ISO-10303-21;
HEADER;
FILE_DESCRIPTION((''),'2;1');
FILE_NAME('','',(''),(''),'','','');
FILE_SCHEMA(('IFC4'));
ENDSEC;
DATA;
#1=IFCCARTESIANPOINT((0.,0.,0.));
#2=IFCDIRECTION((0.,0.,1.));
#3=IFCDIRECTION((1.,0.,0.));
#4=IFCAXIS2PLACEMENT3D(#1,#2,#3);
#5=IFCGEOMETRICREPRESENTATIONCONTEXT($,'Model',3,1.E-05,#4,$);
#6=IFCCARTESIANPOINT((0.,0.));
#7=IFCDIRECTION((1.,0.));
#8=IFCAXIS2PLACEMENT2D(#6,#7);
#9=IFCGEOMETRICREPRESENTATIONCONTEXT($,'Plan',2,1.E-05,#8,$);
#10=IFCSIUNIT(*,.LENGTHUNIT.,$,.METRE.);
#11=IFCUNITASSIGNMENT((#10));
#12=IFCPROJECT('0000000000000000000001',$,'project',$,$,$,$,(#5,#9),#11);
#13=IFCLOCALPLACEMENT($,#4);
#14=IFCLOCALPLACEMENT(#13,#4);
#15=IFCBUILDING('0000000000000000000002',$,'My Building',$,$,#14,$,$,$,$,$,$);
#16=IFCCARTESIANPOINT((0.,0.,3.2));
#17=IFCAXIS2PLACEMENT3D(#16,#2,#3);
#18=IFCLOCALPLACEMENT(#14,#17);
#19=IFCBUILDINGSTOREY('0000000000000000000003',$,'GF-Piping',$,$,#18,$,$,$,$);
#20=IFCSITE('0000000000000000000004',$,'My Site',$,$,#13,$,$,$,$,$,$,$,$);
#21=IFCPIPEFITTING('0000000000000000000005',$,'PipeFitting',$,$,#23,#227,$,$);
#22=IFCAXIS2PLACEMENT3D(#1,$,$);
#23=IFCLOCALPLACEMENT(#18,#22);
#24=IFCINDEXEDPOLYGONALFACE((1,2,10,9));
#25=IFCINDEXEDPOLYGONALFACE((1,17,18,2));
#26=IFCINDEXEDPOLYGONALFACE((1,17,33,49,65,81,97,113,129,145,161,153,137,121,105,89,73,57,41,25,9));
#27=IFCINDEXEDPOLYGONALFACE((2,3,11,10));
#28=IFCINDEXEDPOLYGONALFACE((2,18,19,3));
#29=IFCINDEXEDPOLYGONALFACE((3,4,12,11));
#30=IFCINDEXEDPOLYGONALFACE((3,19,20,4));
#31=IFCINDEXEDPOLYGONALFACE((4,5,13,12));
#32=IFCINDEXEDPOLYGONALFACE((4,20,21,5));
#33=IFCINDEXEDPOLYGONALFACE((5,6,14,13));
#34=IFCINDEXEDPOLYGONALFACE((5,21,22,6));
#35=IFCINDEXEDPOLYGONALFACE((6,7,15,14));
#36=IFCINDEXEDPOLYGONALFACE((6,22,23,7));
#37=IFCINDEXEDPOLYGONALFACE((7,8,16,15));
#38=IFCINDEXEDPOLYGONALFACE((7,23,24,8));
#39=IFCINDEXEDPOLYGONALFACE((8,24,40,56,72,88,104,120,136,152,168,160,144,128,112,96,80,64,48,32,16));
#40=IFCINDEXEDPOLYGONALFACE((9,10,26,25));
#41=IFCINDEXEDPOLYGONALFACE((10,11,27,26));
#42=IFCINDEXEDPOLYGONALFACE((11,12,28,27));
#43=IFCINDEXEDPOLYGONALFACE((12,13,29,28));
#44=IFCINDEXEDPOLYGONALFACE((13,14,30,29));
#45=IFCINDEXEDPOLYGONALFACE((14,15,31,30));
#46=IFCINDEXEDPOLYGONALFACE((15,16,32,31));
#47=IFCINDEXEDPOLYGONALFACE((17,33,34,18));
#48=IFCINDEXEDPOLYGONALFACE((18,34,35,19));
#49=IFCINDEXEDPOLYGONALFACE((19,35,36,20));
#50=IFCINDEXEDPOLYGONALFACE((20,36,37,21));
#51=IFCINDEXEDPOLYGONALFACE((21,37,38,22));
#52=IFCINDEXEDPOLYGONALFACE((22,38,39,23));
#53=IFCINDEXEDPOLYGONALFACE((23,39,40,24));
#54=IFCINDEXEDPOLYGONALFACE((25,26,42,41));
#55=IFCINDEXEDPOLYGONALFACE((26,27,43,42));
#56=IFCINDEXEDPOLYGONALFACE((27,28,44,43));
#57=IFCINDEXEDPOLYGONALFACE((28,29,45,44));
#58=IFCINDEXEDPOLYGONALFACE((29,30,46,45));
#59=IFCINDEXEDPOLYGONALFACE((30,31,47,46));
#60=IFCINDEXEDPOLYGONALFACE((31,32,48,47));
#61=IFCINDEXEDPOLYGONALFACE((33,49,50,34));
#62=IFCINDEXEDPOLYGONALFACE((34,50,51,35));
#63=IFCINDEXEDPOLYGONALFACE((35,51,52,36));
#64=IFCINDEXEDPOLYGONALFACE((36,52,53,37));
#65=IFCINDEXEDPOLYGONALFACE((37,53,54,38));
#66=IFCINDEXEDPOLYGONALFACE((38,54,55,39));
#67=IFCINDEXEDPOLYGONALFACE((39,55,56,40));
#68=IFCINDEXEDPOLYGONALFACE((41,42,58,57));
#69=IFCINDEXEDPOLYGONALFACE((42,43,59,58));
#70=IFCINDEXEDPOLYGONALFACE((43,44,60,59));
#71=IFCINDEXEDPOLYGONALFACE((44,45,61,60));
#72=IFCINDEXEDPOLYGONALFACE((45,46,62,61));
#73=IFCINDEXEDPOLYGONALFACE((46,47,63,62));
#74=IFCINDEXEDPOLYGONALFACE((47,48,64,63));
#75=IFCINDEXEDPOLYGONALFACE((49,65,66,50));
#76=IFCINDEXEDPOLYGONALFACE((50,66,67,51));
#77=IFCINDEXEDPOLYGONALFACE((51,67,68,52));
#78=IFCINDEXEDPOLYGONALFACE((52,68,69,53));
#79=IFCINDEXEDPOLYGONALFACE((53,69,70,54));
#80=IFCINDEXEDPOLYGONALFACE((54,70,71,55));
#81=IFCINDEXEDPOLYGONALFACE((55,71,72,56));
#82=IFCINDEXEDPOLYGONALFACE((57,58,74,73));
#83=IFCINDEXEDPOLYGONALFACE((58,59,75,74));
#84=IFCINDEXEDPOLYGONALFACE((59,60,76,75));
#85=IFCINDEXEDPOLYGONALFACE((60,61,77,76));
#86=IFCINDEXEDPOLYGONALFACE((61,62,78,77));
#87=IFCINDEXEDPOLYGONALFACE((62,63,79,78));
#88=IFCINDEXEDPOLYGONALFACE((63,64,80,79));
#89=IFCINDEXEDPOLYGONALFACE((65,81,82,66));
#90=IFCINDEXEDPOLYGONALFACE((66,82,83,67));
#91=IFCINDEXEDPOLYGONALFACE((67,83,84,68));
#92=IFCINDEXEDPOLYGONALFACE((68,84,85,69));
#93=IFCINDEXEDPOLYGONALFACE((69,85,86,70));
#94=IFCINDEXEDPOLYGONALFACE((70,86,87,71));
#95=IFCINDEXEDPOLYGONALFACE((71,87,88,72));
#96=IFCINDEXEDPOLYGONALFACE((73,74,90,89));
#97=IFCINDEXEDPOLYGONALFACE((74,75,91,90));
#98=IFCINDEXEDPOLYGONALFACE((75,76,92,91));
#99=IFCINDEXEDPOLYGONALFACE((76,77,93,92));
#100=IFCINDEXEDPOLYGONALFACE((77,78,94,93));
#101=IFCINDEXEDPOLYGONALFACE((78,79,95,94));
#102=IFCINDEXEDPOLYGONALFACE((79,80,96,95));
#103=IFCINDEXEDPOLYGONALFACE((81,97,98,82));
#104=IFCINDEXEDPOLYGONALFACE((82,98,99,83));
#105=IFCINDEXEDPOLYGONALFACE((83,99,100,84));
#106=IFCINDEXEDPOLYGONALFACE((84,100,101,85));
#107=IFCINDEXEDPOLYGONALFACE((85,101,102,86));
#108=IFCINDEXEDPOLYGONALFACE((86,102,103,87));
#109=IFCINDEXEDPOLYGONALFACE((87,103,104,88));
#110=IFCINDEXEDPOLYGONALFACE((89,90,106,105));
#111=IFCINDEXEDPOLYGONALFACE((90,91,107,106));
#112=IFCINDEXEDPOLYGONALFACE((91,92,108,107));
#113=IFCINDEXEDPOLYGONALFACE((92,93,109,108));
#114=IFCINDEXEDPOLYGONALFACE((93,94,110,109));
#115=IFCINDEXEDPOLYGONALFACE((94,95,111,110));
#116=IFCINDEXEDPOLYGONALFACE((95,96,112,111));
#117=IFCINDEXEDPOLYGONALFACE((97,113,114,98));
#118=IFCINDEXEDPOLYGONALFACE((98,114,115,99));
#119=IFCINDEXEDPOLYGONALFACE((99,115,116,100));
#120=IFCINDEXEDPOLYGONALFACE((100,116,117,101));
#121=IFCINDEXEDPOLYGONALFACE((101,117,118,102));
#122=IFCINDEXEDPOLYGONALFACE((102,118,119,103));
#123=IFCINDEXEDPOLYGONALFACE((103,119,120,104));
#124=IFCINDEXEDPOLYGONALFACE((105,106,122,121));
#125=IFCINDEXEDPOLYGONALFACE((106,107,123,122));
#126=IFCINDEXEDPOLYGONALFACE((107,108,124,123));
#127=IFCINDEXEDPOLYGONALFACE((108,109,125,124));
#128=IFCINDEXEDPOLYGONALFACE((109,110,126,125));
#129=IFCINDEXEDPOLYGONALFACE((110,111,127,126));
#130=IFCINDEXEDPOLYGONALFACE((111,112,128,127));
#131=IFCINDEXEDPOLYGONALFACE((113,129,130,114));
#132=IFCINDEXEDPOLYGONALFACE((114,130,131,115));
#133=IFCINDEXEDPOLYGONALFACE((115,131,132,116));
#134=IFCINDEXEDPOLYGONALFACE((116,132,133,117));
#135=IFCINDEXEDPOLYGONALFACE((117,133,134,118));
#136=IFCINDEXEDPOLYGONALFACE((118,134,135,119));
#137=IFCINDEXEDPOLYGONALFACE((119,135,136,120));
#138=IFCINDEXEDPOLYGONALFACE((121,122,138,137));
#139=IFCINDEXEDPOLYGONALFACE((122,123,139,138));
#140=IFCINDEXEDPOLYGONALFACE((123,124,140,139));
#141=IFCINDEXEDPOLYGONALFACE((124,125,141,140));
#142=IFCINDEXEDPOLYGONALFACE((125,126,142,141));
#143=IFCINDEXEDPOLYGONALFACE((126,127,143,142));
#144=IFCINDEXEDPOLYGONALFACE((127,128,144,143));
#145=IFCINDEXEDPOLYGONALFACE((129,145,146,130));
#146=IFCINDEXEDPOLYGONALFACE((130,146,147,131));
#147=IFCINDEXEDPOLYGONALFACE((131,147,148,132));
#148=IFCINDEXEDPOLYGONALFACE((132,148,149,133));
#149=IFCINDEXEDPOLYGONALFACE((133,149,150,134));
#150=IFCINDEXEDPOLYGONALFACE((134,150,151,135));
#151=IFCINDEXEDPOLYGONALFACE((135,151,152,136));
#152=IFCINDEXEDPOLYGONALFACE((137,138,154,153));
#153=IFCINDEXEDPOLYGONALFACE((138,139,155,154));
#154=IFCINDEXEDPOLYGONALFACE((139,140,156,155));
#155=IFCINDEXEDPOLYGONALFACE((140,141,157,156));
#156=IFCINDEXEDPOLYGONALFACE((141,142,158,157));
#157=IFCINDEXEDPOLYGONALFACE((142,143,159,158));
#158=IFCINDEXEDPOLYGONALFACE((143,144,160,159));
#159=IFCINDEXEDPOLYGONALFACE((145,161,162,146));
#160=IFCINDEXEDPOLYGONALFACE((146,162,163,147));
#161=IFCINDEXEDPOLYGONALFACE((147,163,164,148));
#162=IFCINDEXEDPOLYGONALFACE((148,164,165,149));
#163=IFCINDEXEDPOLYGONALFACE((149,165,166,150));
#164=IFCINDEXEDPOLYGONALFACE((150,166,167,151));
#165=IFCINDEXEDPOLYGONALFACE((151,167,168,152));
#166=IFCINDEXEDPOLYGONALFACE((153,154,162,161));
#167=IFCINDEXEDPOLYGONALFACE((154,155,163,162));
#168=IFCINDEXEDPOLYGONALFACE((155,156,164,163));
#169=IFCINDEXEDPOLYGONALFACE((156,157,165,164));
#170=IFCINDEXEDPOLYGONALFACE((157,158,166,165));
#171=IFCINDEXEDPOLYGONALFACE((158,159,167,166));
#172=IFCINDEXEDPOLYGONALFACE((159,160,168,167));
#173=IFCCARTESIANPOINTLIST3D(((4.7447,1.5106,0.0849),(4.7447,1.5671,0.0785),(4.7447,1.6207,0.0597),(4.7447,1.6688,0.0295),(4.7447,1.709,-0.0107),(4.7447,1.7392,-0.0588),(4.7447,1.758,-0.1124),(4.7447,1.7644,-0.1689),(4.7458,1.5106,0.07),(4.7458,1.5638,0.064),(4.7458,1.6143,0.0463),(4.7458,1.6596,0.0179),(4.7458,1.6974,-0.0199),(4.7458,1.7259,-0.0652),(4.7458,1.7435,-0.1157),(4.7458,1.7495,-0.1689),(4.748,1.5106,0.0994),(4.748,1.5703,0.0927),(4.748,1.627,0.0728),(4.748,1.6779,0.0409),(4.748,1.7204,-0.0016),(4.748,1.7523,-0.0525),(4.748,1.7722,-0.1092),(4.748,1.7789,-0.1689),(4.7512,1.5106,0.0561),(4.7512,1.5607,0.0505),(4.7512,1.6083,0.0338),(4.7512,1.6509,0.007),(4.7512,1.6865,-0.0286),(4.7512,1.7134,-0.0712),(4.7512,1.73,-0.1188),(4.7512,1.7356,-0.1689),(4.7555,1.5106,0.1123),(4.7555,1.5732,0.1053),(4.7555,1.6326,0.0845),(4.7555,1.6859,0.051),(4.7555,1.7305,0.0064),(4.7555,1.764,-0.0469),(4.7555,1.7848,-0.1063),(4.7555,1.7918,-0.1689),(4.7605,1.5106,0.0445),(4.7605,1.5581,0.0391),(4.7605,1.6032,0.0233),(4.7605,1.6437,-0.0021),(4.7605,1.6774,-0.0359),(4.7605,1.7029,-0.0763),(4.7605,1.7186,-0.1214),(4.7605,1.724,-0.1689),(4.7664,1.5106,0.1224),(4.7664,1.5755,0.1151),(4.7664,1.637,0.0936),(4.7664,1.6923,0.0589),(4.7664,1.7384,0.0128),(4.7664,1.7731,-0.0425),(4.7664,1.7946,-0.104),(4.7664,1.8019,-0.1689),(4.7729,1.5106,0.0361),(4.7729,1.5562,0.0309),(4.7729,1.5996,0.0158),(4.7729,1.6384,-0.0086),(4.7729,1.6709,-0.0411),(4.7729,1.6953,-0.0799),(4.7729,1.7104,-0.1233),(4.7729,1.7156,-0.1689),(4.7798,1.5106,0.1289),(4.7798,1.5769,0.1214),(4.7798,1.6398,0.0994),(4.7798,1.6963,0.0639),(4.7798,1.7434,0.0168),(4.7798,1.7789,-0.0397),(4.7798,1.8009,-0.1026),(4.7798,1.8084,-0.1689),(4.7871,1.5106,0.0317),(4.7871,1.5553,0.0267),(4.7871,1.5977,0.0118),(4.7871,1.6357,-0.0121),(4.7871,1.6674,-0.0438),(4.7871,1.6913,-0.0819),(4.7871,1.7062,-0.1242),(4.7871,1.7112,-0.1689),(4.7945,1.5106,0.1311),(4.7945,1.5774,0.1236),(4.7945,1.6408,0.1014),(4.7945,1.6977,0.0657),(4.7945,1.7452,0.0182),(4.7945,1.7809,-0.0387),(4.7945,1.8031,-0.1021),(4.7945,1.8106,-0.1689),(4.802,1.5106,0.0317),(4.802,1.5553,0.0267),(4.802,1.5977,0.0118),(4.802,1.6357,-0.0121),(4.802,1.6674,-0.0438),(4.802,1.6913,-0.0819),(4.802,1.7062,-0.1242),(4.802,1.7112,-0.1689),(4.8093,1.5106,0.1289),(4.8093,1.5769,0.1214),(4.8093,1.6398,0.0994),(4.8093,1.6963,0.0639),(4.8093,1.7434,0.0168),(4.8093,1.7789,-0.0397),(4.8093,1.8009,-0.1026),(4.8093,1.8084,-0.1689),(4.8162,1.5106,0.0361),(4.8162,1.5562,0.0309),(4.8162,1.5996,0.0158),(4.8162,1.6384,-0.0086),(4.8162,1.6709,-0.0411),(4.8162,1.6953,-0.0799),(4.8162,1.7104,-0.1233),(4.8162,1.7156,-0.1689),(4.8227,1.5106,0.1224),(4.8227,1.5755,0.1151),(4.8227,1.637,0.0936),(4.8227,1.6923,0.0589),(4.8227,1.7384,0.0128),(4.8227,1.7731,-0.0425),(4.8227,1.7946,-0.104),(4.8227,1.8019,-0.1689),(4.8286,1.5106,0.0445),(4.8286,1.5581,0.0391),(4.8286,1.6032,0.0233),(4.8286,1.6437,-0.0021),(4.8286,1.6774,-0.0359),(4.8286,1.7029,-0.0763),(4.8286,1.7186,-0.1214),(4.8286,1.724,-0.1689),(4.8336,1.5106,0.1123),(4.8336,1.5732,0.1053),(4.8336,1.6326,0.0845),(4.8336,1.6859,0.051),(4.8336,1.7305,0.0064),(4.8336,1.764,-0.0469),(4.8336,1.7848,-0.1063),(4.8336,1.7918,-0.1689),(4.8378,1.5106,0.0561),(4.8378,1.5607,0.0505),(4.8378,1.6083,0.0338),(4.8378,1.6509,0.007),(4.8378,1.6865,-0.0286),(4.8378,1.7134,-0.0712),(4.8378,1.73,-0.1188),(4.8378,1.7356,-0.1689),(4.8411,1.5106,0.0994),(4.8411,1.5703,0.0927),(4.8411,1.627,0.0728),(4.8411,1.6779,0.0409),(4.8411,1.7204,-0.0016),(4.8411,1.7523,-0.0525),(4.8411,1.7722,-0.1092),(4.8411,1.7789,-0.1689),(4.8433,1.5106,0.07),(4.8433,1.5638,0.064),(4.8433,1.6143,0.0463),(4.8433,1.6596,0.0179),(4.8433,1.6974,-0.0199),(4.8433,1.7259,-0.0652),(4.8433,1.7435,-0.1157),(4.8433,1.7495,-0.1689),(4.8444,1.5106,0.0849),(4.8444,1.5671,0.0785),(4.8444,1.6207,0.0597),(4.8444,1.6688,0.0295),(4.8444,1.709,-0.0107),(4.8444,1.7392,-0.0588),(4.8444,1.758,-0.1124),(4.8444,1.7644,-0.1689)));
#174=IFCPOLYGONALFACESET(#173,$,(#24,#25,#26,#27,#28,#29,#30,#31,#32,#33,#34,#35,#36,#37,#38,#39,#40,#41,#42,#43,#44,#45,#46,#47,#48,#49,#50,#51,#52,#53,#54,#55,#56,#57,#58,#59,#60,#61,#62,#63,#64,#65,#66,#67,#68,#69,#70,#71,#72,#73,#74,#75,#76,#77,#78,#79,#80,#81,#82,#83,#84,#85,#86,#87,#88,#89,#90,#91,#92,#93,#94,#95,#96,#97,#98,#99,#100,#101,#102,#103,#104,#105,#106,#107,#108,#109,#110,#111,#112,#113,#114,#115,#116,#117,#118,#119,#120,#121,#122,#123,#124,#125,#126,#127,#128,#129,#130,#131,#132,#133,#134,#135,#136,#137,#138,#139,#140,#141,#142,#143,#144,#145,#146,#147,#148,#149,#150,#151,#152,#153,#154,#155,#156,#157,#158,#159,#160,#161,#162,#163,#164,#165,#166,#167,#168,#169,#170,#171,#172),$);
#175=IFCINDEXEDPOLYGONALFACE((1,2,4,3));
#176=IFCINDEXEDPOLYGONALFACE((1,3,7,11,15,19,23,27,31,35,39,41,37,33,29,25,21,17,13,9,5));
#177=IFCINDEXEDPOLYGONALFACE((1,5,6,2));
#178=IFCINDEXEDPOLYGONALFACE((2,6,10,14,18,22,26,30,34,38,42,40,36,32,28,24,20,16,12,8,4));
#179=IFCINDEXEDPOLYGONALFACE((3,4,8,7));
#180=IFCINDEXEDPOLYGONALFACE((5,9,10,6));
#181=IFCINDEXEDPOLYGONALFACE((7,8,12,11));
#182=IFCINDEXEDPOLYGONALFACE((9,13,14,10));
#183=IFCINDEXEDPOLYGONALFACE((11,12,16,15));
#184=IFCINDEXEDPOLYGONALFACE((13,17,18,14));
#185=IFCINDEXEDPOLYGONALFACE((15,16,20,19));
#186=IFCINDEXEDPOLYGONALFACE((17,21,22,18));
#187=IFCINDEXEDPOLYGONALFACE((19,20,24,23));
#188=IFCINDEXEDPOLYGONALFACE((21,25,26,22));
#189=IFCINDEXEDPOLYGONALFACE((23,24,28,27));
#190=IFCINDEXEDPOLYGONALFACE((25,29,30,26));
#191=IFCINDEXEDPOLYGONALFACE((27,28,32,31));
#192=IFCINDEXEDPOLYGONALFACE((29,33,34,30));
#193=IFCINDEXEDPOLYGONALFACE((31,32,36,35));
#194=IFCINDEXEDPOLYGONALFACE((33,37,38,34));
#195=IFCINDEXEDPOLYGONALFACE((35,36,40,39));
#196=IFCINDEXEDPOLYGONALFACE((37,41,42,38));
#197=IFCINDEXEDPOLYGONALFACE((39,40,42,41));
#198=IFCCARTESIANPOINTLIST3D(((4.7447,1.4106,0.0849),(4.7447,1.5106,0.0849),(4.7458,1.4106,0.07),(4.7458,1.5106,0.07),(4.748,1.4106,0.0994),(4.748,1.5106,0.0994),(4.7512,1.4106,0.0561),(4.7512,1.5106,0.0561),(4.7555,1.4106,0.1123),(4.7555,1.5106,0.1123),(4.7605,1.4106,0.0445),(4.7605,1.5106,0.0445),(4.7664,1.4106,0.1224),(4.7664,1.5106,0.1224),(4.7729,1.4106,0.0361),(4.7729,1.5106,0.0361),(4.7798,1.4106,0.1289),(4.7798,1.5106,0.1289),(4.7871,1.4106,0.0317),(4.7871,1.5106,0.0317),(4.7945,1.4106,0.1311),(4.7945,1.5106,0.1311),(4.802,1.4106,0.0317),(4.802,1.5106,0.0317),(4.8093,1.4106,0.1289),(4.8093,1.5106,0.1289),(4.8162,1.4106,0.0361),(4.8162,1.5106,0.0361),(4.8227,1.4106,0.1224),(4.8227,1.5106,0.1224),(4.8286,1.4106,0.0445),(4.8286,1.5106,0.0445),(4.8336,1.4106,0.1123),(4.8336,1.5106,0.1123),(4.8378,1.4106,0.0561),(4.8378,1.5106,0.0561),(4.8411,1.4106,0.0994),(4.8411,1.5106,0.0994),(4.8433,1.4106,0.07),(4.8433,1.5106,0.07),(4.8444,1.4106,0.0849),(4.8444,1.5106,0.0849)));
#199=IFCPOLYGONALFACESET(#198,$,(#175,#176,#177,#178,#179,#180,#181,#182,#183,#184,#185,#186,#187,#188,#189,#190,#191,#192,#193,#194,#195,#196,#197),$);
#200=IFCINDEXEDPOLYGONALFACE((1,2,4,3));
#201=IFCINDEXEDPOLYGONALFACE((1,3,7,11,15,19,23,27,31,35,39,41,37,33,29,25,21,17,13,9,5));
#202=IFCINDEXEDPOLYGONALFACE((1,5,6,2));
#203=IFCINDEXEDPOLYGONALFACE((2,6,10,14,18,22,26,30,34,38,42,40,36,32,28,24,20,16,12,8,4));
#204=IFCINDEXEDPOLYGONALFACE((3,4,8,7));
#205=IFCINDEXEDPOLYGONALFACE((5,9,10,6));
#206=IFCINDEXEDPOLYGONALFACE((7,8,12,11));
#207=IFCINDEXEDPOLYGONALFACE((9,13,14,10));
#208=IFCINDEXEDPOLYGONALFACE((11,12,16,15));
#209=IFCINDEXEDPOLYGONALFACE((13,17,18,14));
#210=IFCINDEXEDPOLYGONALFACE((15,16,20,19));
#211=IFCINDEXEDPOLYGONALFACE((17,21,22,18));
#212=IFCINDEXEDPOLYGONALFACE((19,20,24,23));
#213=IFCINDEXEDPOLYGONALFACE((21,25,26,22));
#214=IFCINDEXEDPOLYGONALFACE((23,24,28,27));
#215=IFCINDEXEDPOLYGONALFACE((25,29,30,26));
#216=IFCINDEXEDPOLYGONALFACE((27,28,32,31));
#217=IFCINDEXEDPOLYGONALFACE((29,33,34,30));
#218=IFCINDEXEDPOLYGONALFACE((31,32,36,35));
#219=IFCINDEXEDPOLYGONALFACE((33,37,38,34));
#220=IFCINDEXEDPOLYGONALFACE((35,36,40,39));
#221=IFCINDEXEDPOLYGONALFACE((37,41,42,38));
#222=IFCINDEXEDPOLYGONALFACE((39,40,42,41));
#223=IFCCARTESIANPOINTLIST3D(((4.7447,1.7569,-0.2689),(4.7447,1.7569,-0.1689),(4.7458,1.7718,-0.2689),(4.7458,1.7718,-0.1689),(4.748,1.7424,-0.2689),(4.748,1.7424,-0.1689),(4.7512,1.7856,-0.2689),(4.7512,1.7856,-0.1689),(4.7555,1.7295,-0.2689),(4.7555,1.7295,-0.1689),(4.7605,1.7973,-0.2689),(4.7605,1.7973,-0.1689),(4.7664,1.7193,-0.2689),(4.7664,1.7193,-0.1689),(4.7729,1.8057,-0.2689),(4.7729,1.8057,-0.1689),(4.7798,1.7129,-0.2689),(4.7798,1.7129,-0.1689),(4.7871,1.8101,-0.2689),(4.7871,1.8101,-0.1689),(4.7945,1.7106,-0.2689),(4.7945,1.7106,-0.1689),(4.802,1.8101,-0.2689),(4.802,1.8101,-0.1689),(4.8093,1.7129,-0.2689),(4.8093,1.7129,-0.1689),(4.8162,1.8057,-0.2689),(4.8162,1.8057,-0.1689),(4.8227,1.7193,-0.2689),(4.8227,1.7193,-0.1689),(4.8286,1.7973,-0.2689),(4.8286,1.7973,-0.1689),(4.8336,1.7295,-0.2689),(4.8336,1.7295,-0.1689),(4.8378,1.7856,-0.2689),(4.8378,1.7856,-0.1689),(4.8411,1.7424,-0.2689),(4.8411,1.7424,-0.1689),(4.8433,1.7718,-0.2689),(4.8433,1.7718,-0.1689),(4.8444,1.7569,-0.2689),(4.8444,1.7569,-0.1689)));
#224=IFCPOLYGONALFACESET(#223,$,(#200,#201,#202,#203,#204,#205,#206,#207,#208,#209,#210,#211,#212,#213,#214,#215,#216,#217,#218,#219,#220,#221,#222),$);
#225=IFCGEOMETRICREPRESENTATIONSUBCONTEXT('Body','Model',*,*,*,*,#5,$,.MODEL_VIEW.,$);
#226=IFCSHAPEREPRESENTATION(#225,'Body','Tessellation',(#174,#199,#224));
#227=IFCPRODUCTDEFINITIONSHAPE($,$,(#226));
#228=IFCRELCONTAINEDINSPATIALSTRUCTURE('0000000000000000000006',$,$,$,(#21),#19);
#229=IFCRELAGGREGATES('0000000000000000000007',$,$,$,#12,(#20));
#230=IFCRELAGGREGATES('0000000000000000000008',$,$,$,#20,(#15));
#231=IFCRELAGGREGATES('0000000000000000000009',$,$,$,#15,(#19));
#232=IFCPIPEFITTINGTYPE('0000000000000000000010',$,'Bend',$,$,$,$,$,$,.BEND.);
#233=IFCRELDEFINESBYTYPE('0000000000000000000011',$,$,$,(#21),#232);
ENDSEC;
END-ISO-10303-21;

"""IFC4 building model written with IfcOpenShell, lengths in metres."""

from ifc_helpers import new_model, entity, si_unit, frame, origin_with_axes, origin_2d_with_axis, place, context, subcontext, project, spatial, circle, extrude, source, transform, mapped, type_object, type_shapes, element, save


model = new_model("IFC4")

# Units and contexts
model_context = context("Model", 3, precision=1e-05, world=origin_with_axes())
plan_context = context("Plan", 2, precision=1e-05, world=origin_2d_with_axis())
body_context = subcontext(model_context, "Body", "Model", "MODEL_VIEW")
ifc_project = project(units=[si_unit("LENGTHUNIT", "METRE")], contexts=[model_context, plan_context])

# Site, building, storey
site_placement = place(None, origin_with_axes())
site = spatial("IfcSite", under=ifc_project, at=site_placement, Name="My Site")
building_placement = place(site_placement, origin_with_axes())
building = spatial("IfcBuilding", under=site, at=building_placement, Name="My Building")
storey_placement = place(building_placement, frame((0.0, 0.0, 3.2), z_axis=(0.0, 0.0, 1.0), x_axis=(1.0, 0.0, 0.0)))
storey = spatial("IfcBuildingStorey", under=building, at=storey_placement, Name="GF-Piping")

# Pipe fitting
pipe_fitting_type = type_object("IfcPipeFittingType", Name="Bend", PredefinedType="BEND")
shared_shape = source(origin_with_axes(), body_context, "Body", "SolidModel", [
    entity("IfcSweptDiskSolid", entity("IfcIndexedPolyCurve", entity("IfcCartesianPointList3D", [[0.0, 0.0, 0.1], [-0.0732, 0.0, 0.2768], [-0.25, 0.0, 0.35]]), [entity("IfcArcIndex", [1, 2, 3])]), 0.05),
    extrude(circle(Radius=0.05), origin_with_axes(), (0.0, 0.0, 1.0), 0.1),
    extrude(circle(Radius=0.05), frame((-0.25, 0.0, 0.35), z_axis=(-1.0, 0.0, 0.0), x_axis=(0.0, 0.0, -1.0)), (0.0, 0.0, 1.0), 0.1),
])
type_shapes(pipe_fitting_type, [shared_shape])
for number, where, z_axis, x_axis, name in (
    (1, (4.7945, 1.4106, 0.0811), (0.0, 1.0, 0.0), (0.0, 0.0, 1.0), "PipeFitting"),
):
    element("IfcPipeFitting", number, at=place(storey_placement, frame(where, z_axis=z_axis, x_axis=x_axis)), inside=storey, type_object=pipe_fitting_type, Name=name, context=body_context, shape_type="MappedRepresentation", body=[
        mapped(shared_shape, transform((0.0, 0.0, 0.0), x_axis=(1.0, 0.0, 0.0), y_axis=(0.0, 1.0, 0.0), z_axis=(0.0, 0.0, 1.0), scale=1.0)),
    ])

save(model, "model.ifc")
